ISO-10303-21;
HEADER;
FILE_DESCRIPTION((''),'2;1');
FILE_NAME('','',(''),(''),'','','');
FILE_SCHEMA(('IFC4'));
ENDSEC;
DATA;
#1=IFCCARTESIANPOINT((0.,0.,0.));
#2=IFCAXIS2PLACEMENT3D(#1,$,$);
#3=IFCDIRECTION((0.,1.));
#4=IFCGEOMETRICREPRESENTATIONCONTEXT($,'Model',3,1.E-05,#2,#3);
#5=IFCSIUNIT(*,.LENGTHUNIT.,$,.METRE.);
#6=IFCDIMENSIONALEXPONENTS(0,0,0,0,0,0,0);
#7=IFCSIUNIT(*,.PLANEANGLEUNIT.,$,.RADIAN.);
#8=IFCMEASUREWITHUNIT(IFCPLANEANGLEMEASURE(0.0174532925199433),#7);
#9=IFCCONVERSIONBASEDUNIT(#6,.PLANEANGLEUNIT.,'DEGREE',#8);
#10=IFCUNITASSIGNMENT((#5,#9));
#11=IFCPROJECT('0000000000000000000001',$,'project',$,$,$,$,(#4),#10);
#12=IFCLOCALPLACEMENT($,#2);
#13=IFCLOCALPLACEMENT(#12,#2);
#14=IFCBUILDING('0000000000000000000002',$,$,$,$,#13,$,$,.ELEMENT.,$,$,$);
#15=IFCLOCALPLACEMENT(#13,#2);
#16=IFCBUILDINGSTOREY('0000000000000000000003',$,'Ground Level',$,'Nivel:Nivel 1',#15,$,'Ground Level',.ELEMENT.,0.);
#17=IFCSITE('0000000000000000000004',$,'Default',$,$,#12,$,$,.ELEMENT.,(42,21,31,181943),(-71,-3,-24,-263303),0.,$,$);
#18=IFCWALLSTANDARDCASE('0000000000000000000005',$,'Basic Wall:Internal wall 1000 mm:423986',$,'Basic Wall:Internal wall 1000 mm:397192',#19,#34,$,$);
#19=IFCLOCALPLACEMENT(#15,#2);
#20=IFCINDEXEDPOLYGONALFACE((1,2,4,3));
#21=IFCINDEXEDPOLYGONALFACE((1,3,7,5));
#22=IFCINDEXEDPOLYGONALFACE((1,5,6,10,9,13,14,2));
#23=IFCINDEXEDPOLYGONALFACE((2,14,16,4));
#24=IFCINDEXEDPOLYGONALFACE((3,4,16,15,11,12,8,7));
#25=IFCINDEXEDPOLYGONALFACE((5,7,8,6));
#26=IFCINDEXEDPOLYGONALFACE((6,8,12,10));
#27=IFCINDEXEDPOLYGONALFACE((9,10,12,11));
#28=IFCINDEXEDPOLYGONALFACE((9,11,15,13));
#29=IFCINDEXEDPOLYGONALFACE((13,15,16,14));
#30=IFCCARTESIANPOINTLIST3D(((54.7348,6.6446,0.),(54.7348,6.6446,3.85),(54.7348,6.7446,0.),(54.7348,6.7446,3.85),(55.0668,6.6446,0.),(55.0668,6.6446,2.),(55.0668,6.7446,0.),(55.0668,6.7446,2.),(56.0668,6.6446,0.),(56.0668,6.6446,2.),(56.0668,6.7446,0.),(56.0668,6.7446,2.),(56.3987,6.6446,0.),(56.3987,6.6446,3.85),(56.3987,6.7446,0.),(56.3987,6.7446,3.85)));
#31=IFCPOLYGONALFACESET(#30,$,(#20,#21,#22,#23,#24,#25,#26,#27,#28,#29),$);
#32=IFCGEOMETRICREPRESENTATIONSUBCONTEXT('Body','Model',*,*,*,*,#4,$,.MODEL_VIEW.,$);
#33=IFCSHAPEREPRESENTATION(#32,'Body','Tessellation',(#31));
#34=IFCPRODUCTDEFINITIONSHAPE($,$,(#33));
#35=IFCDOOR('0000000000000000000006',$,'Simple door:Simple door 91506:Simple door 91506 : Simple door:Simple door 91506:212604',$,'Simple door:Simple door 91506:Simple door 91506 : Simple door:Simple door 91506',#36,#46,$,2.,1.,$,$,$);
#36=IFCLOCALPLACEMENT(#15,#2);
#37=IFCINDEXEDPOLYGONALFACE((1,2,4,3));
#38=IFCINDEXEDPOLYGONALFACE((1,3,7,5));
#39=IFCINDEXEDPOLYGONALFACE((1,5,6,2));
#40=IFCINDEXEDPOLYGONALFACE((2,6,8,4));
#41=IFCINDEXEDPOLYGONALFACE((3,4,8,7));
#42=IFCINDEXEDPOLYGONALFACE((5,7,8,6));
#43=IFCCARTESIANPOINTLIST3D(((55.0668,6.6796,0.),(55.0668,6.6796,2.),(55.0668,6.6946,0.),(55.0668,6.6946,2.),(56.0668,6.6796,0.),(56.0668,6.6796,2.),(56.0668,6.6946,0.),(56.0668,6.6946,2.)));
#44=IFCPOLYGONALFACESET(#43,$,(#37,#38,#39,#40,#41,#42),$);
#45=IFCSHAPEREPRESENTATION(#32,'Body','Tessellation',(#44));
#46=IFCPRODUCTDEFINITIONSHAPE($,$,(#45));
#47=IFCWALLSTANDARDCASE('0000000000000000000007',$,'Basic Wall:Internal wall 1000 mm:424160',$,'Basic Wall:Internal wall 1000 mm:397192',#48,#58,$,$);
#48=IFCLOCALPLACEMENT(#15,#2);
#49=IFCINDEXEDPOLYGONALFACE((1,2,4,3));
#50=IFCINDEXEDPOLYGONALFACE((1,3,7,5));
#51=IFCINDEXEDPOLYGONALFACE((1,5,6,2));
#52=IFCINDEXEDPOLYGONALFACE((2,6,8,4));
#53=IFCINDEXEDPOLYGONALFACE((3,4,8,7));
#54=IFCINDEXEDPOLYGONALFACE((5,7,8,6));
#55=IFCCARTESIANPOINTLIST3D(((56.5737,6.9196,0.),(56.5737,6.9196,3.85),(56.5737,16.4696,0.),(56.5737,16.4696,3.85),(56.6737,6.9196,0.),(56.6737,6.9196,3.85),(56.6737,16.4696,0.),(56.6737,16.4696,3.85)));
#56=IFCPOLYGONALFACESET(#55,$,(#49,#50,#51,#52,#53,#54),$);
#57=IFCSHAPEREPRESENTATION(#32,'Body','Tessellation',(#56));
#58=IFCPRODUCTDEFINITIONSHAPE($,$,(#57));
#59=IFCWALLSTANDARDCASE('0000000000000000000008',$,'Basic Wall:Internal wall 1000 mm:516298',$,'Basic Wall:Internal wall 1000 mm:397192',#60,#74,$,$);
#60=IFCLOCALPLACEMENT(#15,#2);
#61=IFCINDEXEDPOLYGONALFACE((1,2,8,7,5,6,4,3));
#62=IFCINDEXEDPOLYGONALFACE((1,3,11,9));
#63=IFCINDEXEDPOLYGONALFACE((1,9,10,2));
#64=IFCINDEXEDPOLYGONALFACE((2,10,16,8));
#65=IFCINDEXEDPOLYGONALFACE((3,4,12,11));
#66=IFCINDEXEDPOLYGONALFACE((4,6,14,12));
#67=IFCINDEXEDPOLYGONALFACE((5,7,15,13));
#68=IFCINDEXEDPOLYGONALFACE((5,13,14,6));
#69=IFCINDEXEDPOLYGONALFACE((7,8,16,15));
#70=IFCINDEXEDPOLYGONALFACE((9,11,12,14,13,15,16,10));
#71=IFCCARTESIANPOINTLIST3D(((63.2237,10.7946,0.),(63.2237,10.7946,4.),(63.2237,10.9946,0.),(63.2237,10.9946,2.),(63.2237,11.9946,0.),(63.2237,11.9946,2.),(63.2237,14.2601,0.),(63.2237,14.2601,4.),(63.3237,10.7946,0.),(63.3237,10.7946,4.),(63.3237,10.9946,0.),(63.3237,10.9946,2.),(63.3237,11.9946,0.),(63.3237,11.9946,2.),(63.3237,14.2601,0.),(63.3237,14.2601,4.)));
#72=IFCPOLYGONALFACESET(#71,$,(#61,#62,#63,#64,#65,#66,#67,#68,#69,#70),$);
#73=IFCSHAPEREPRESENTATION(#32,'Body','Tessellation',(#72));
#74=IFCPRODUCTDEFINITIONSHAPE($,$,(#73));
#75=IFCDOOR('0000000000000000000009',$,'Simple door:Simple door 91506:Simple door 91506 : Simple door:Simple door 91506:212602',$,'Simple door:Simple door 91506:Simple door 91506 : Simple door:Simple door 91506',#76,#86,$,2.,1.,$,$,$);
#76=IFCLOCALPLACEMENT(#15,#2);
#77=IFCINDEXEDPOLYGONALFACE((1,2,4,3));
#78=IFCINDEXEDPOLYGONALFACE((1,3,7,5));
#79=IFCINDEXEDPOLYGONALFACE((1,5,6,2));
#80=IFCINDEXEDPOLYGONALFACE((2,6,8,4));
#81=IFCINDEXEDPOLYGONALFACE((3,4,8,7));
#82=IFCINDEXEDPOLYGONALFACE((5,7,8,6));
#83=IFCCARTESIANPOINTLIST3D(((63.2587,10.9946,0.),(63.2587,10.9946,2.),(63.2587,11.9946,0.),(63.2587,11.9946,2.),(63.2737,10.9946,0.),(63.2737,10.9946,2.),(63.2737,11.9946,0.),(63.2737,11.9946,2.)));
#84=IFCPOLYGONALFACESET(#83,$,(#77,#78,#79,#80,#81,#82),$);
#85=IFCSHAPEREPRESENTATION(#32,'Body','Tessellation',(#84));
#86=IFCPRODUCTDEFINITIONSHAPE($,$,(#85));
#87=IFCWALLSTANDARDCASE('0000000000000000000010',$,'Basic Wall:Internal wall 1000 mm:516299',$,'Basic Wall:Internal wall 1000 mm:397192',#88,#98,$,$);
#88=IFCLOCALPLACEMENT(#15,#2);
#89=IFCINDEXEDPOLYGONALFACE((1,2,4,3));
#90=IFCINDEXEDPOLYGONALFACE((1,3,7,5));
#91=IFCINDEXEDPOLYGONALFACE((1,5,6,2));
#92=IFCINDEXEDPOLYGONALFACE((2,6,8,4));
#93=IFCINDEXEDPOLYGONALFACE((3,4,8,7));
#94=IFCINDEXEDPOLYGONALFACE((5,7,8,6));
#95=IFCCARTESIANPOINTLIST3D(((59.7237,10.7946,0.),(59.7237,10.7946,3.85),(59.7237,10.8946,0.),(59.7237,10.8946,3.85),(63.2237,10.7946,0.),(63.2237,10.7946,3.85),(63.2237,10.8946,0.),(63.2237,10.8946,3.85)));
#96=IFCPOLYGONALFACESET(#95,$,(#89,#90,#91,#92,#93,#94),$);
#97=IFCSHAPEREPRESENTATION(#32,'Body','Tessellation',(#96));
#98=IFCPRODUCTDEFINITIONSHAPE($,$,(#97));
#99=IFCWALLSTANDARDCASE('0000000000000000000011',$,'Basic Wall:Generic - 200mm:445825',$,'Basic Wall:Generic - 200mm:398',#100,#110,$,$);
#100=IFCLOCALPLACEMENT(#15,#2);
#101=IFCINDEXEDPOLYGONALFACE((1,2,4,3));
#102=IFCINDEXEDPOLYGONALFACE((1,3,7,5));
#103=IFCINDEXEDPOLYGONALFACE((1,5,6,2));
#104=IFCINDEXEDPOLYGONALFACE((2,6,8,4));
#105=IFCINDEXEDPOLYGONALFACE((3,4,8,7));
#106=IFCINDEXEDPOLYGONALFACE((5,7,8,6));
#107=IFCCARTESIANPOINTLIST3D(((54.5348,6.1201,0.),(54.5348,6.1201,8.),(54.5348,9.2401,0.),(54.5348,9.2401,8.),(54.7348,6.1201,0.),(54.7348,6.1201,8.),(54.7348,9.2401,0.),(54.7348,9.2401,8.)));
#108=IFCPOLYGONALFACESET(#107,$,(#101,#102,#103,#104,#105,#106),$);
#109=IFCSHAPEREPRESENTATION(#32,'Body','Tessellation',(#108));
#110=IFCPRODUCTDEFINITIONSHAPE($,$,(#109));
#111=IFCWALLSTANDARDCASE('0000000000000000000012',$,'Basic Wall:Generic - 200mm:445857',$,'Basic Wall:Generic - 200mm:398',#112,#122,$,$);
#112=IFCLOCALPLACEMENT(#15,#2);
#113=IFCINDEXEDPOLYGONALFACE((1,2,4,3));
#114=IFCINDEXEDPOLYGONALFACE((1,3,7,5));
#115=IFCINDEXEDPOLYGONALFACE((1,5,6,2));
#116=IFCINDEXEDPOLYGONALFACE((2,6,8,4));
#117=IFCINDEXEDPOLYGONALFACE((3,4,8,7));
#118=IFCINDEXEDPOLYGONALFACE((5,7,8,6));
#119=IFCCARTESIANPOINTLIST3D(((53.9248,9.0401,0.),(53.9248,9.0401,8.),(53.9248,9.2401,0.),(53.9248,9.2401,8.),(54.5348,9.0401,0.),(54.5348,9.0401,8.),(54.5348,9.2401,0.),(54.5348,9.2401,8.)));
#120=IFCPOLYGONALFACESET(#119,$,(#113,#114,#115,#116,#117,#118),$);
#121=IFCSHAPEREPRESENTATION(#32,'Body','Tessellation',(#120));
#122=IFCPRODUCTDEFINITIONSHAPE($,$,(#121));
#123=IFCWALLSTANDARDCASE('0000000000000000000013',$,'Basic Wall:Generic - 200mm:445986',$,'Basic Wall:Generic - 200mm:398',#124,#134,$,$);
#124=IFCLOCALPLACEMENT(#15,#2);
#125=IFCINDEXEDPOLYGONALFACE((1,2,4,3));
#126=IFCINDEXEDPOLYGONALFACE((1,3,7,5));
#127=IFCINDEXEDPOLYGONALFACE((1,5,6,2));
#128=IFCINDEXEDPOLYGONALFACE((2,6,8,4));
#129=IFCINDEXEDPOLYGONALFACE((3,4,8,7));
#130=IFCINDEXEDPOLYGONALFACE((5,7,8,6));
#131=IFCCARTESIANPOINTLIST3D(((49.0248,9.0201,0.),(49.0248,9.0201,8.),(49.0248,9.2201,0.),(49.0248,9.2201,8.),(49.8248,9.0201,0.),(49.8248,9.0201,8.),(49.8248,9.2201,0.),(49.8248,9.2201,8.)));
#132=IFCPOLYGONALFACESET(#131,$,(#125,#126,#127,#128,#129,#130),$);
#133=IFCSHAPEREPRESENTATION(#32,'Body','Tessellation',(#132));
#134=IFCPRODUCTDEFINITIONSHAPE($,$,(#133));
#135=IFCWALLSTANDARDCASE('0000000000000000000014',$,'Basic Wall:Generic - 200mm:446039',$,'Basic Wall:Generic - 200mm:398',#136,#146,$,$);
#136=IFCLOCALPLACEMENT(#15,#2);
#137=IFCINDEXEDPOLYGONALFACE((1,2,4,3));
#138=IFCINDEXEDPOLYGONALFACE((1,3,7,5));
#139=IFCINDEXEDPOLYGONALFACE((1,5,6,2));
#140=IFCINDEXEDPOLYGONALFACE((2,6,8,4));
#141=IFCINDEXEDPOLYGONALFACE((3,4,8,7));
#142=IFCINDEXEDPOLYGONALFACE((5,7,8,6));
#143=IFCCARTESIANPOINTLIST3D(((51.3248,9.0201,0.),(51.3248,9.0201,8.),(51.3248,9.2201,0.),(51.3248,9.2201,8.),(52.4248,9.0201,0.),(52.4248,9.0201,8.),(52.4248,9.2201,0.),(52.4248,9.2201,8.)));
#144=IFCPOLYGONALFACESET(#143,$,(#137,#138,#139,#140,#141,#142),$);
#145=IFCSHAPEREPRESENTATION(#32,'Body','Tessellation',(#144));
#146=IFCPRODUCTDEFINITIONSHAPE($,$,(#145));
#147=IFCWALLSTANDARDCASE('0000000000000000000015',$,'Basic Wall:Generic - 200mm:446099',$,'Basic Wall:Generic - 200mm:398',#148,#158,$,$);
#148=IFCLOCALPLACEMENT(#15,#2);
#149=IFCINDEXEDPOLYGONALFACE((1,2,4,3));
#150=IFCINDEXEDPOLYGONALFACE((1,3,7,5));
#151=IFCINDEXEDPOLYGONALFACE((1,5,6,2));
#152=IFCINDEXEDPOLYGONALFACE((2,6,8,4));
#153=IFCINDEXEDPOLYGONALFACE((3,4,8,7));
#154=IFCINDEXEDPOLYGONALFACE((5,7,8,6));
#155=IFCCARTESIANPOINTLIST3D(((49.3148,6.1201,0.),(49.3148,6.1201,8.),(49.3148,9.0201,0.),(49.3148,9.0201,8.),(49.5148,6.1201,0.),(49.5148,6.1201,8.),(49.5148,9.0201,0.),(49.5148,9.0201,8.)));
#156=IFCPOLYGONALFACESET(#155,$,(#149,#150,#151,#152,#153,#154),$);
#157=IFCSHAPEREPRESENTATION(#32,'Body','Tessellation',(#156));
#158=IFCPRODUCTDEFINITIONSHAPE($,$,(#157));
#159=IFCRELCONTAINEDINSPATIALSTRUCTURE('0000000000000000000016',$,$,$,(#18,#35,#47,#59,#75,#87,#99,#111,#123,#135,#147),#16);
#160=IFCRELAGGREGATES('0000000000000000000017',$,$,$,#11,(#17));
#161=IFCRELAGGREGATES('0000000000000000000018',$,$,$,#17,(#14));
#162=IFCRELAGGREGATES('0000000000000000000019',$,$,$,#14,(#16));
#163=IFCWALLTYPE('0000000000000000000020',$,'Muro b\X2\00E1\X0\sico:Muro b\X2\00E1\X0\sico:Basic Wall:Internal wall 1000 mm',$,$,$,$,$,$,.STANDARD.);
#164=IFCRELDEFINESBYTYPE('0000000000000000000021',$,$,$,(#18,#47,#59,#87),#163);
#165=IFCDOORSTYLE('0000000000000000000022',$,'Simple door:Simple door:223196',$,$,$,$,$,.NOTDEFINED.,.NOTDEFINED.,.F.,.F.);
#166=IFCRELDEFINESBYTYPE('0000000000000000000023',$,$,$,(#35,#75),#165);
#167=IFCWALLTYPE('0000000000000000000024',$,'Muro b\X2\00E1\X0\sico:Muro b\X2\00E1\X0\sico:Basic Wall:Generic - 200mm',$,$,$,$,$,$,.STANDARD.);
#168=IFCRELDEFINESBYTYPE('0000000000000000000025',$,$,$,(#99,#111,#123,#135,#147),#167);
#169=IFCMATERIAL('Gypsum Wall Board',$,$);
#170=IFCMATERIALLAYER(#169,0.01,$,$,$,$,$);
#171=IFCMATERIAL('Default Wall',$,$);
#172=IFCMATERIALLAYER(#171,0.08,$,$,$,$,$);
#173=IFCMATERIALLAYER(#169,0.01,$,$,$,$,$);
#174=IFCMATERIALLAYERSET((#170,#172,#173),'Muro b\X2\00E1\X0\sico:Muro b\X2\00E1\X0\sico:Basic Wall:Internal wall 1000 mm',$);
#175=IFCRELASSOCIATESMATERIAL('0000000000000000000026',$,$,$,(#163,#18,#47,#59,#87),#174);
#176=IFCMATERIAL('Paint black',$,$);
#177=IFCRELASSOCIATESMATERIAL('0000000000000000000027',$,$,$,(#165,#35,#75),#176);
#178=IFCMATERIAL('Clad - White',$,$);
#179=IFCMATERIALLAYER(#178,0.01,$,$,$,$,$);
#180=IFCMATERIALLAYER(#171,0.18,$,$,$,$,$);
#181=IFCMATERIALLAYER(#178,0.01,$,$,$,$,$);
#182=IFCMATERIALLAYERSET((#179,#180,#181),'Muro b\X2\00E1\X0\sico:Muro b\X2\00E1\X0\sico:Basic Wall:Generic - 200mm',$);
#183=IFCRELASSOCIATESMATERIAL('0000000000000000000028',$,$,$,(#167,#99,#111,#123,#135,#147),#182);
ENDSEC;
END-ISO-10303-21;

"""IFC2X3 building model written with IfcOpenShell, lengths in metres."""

from ifc_helpers import new_model, entity, si_unit, converted_unit, direction, frame, frame_2d, origin, origin_2d_with_axis, place, context, subcontext, project, spatial, rectangle, extrude, source, transform, mapped, material, layer, layer_set, layer_usage, type_object, type_shapes, element, fill, save


model = new_model("IFC2X3")

# Units and contexts
model_context = context("Model", 3, precision=1e-05, world=origin(), true_north=direction((0.0, 1.0)))
body_context = subcontext(model_context, "Body", "Model", "MODEL_VIEW")
ifc_project = project(units=[si_unit("LENGTHUNIT", "METRE"), converted_unit("PLANEANGLEUNIT", "DEGREE", entity("IfcPlaneAngleMeasure", 0.0174532925199433), si_unit("PLANEANGLEUNIT", "RADIAN"), dimensions=[0, 0, 0, 0, 0, 0, 0])], contexts=[model_context])

# Site, building, storey
site_placement = place(None, origin())
site = spatial("IfcSite", under=ifc_project, at=site_placement, Name="Default", CompositionType="ELEMENT", RefLatitude=(42, 21, 31, 181943), RefLongitude=(-71, -3, -24, -263303), RefElevation=0.0)
building_placement = place(site_placement, origin())
building = spatial("IfcBuilding", under=site, at=building_placement, CompositionType="ELEMENT")
storey_placement = place(building_placement, origin())
storey = spatial("IfcBuildingStorey", under=building, at=storey_placement, Name="Ground Level", ObjectType="Nivel:Nivel 1", LongName="Ground Level", CompositionType="ELEMENT", Elevation=0.0)

# Wall, opening, door
ifc_material_1 = material(Name="Gypsum Wall Board")
ifc_layer_1 = layer(ifc_material_1, 0.01)
ifc_material_2 = material(Name="Default Wall")
ifc_layer_2 = layer(ifc_material_2, 0.08)
ifc_layer_3 = layer(ifc_material_1, 0.01)
ifc_layer_set_1 = layer_set([ifc_layer_1, ifc_layer_2, ifc_layer_3], Name="Muro básico:Muro básico:Basic Wall:Internal wall 1000 mm")
ifc_layer_usage_1 = layer_usage(ifc_layer_set_1, "AXIS2", "NEGATIVE", 0.05)
wall_type_1 = type_object("IfcWallType", Name="Muro básico:Muro básico:Basic Wall:Internal wall 1000 mm", PredefinedType="STANDARD", material=ifc_layer_set_1)
wall_1_placement = place(storey_placement, frame((56.3987, 6.6946, 0.0), z_axis=(0.0, 0.0, 1.0), x_axis=(-1.0, 0.0, 0.0)))
wall_1 = element("IfcWallStandardCase", 1, at=wall_1_placement, inside=storey, type_object=wall_type_1, material=ifc_layer_usage_1, Name="Basic Wall:Internal wall 1000 mm:423986", ObjectType="Basic Wall:Internal wall 1000 mm:397192", context=body_context, shape_type="SweptSolid", body=[
    extrude(rectangle(XDim=1.6639, YDim=0.1, at=frame_2d((0.8319, 0.0), x_axis=(1.0, 0.0))), origin(), (0.0, 0.0, 1.0), 3.85),
])
opening_1_placement = place(wall_1_placement, frame((56.3987, 6.6946, 0.0), z_axis=(0.0, 0.0, 1.0), x_axis=(-1.0, 0.0, 0.0)))
opening_1 = element("IfcOpeningElement", 2, at=opening_1_placement, cuts=wall_1, ObjectType="Opening", context=body_context, shape_type="SweptSolid", body=[
    extrude(rectangle(XDim=2.0, YDim=1.0, at=frame_2d((0.0, 0.0), x_axis=(0.0, 1.0))), frame((55.5668, 6.7467, 1.0), z_axis=(0.0, -1.0, 0.0), x_axis=(1.0, 0.0, 0.0)), (0.0, 0.0, 1.0), 0.104),
])
ifc_material_3 = material(Name="Paint black")
door_style = type_object("IfcDoorStyle", Name="Simple door:Simple door:223196", ConstructionType="NOTDEFINED", OperationType="NOTDEFINED", ParameterTakesPrecedence=False, Sizeable=False, material=ifc_material_3)
shared_shape = source(origin(), body_context, "Body", "SweptSolid", [
    extrude(rectangle(XDim=1.0, YDim=0.015, at=origin_2d_with_axis()), frame((0.5, 0.0445, 0.0)), (0.0, 0.0, 1.0), 2.0),
])
type_shapes(door_style, [shared_shape])
door_1_placement = place(opening_1_placement, frame((55.0668, 6.6426, 0.0)))
door_1 = element("IfcDoor", 3, at=door_1_placement, inside=storey, type_object=door_style, material=ifc_material_3, Name="Simple door:Simple door 91506:Simple door 91506 : Simple door:Simple door 91506:212604", ObjectType="Simple door:Simple door 91506:Simple door 91506 : Simple door:Simple door 91506", OverallHeight=2.0, OverallWidth=1.0, context=body_context, shape_type="MappedRepresentation", body=[
    mapped(shared_shape, transform((0.0, 0.0, 0.0), scale=1.0)),
])
fill(opening_1, door_1)

# Wall
ifc_layer_usage_2 = layer_usage(ifc_layer_set_1, "AXIS2", "NEGATIVE", 0.05)
wall_2_placement = place(storey_placement, frame((56.6237, 6.9196, 0.0), z_axis=(0.0, 0.0, 1.0), x_axis=(0.0, 1.0, 0.0)))
element("IfcWallStandardCase", 4, at=wall_2_placement, inside=storey, type_object=wall_type_1, material=ifc_layer_usage_2, Name="Basic Wall:Internal wall 1000 mm:424160", ObjectType="Basic Wall:Internal wall 1000 mm:397192", context=body_context, shape_type="SweptSolid", body=[
    extrude(rectangle(XDim=9.55, YDim=0.1, at=frame_2d((4.775, 0.0), x_axis=(-1.0, 0.0))), origin(), (0.0, 0.0, 1.0), 3.85),
])

# Wall, opening, door
ifc_layer_usage_3 = layer_usage(ifc_layer_set_1, "AXIS2", "NEGATIVE", 0.05)
wall_3_placement = place(storey_placement, frame((63.2737, 10.7946, 0.0), z_axis=(0.0, 0.0, 1.0), x_axis=(0.0, 1.0, 0.0)))
wall_3 = element("IfcWallStandardCase", 5, at=wall_3_placement, inside=storey, type_object=wall_type_1, material=ifc_layer_usage_3, Name="Basic Wall:Internal wall 1000 mm:516298", ObjectType="Basic Wall:Internal wall 1000 mm:397192", context=body_context, shape_type="SweptSolid", body=[
    extrude(rectangle(XDim=3.4655, YDim=0.1, at=frame_2d((1.7327, 0.0), x_axis=(1.0, 0.0))), origin(), (0.0, 0.0, 1.0), 4.0),
])
opening_2_placement = place(wall_3_placement, frame((-10.7946, 63.2737, 0.0), z_axis=(0.0, 0.0, 1.0), x_axis=(0.0, -1.0, 0.0)))
opening_2 = element("IfcOpeningElement", 6, at=opening_2_placement, cuts=wall_3, ObjectType="Opening", context=body_context, shape_type="SweptSolid", body=[
    extrude(rectangle(XDim=2.0, YDim=1.0, at=frame_2d((0.0, 0.0), x_axis=(0.0, 1.0))), frame((63.3257, 11.4946, 1.0), z_axis=(-1.0, 0.0, 0.0), x_axis=(0.0, -1.0, 0.0)), (0.0, 0.0, 1.0), 0.104),
])
door_2_placement = place(opening_2_placement, frame((63.2217, 11.9946, 0.0), z_axis=(0.0, 0.0, 1.0), x_axis=(0.0, -1.0, 0.0)))
door_2 = element("IfcDoor", 7, at=door_2_placement, inside=storey, type_object=door_style, material=ifc_material_3, Name="Simple door:Simple door 91506:Simple door 91506 : Simple door:Simple door 91506:212602", ObjectType="Simple door:Simple door 91506:Simple door 91506 : Simple door:Simple door 91506", OverallHeight=2.0, OverallWidth=1.0, context=body_context, shape_type="MappedRepresentation", body=[
    mapped(shared_shape, transform((0.0, 0.0, 0.0), scale=1.0)),
])
fill(opening_2, door_2)

# Walls
ifc_layer_usage_4 = layer_usage(ifc_layer_set_1, "AXIS2", "NEGATIVE", 0.05)
wall_4_placement = place(storey_placement, frame((59.7237, 10.8446, 0.0)))
element("IfcWallStandardCase", 8, at=wall_4_placement, inside=storey, type_object=wall_type_1, material=ifc_layer_usage_4, Name="Basic Wall:Internal wall 1000 mm:516299", ObjectType="Basic Wall:Internal wall 1000 mm:397192", context=body_context, shape_type="SweptSolid", body=[
    extrude(rectangle(XDim=3.5, YDim=0.1, at=frame_2d((1.75, 0.0), x_axis=(-1.0, 0.0))), origin(), (0.0, 0.0, 1.0), 3.85),
])
ifc_material_4 = material(Name="Clad - White")
ifc_layer_4 = layer(ifc_material_4, 0.01)
ifc_layer_5 = layer(ifc_material_2, 0.18)
ifc_layer_6 = layer(ifc_material_4, 0.01)
ifc_layer_set_2 = layer_set([ifc_layer_4, ifc_layer_5, ifc_layer_6], Name="Muro básico:Muro básico:Basic Wall:Generic - 200mm")
ifc_layer_usage_5 = layer_usage(ifc_layer_set_2, "AXIS2", "NEGATIVE", 0.1)
wall_type_2 = type_object("IfcWallType", Name="Muro básico:Muro básico:Basic Wall:Generic - 200mm", PredefinedType="STANDARD", material=ifc_layer_set_2)
wall_5_placement = place(storey_placement, frame((54.6348, 6.1201, 0.0), z_axis=(0.0, 0.0, 1.0), x_axis=(0.0, 1.0, 0.0)))
element("IfcWallStandardCase", 9, at=wall_5_placement, inside=storey, type_object=wall_type_2, material=ifc_layer_usage_5, Name="Basic Wall:Generic - 200mm:445825", ObjectType="Basic Wall:Generic - 200mm:398", context=body_context, shape_type="SweptSolid", body=[
    extrude(rectangle(XDim=3.12, YDim=0.2, at=frame_2d((1.56, 0.0), x_axis=(-1.0, 0.0))), origin(), (0.0, 0.0, 1.0), 8.0),
])
ifc_layer_usage_6 = layer_usage(ifc_layer_set_2, "AXIS2", "NEGATIVE", 0.1)
wall_6_placement = place(storey_placement, frame((54.5348, 9.1401, 0.0), z_axis=(0.0, 0.0, 1.0), x_axis=(-1.0, 0.0, 0.0)))
element("IfcWallStandardCase", 10, at=wall_6_placement, inside=storey, type_object=wall_type_2, material=ifc_layer_usage_6, Name="Basic Wall:Generic - 200mm:445857", ObjectType="Basic Wall:Generic - 200mm:398", context=body_context, shape_type="SweptSolid", body=[
    extrude(rectangle(XDim=0.61, YDim=0.2, at=frame_2d((0.305, 0.0), x_axis=(-1.0, 0.0))), origin(), (0.0, 0.0, 1.0), 8.0),
])
ifc_layer_usage_7 = layer_usage(ifc_layer_set_2, "AXIS2", "NEGATIVE", 0.1)
wall_7_placement = place(storey_placement, frame((49.0248, 9.1201, 0.0)))
element("IfcWallStandardCase", 11, at=wall_7_placement, inside=storey, type_object=wall_type_2, material=ifc_layer_usage_7, Name="Basic Wall:Generic - 200mm:445986", ObjectType="Basic Wall:Generic - 200mm:398", context=body_context, shape_type="SweptSolid", body=[
    extrude(rectangle(XDim=0.8, YDim=0.2, at=frame_2d((0.4, 0.0), x_axis=(-1.0, 0.0))), origin(), (0.0, 0.0, 1.0), 8.0),
])
ifc_layer_usage_8 = layer_usage(ifc_layer_set_2, "AXIS2", "NEGATIVE", 0.1)
wall_8_placement = place(storey_placement, frame((51.3248, 9.1201, 0.0)))
element("IfcWallStandardCase", 12, at=wall_8_placement, inside=storey, type_object=wall_type_2, material=ifc_layer_usage_8, Name="Basic Wall:Generic - 200mm:446039", ObjectType="Basic Wall:Generic - 200mm:398", context=body_context, shape_type="SweptSolid", body=[
    extrude(rectangle(XDim=1.1, YDim=0.2, at=frame_2d((0.55, 0.0), x_axis=(-1.0, 0.0))), origin(), (0.0, 0.0, 1.0), 8.0),
])
ifc_layer_usage_9 = layer_usage(ifc_layer_set_2, "AXIS2", "NEGATIVE", 0.1)
wall_9_placement = place(storey_placement, frame((49.4148, 9.0201, 0.0), z_axis=(0.0, 0.0, 1.0), x_axis=(0.0, -1.0, 0.0)))
element("IfcWallStandardCase", 13, at=wall_9_placement, inside=storey, type_object=wall_type_2, material=ifc_layer_usage_9, Name="Basic Wall:Generic - 200mm:446099", ObjectType="Basic Wall:Generic - 200mm:398", context=body_context, shape_type="SweptSolid", body=[
    extrude(rectangle(XDim=2.9, YDim=0.2, at=frame_2d((1.45, 0.0), x_axis=(-1.0, 0.0))), origin(), (0.0, 0.0, 1.0), 8.0),
])

save(model, "model.ifc")
